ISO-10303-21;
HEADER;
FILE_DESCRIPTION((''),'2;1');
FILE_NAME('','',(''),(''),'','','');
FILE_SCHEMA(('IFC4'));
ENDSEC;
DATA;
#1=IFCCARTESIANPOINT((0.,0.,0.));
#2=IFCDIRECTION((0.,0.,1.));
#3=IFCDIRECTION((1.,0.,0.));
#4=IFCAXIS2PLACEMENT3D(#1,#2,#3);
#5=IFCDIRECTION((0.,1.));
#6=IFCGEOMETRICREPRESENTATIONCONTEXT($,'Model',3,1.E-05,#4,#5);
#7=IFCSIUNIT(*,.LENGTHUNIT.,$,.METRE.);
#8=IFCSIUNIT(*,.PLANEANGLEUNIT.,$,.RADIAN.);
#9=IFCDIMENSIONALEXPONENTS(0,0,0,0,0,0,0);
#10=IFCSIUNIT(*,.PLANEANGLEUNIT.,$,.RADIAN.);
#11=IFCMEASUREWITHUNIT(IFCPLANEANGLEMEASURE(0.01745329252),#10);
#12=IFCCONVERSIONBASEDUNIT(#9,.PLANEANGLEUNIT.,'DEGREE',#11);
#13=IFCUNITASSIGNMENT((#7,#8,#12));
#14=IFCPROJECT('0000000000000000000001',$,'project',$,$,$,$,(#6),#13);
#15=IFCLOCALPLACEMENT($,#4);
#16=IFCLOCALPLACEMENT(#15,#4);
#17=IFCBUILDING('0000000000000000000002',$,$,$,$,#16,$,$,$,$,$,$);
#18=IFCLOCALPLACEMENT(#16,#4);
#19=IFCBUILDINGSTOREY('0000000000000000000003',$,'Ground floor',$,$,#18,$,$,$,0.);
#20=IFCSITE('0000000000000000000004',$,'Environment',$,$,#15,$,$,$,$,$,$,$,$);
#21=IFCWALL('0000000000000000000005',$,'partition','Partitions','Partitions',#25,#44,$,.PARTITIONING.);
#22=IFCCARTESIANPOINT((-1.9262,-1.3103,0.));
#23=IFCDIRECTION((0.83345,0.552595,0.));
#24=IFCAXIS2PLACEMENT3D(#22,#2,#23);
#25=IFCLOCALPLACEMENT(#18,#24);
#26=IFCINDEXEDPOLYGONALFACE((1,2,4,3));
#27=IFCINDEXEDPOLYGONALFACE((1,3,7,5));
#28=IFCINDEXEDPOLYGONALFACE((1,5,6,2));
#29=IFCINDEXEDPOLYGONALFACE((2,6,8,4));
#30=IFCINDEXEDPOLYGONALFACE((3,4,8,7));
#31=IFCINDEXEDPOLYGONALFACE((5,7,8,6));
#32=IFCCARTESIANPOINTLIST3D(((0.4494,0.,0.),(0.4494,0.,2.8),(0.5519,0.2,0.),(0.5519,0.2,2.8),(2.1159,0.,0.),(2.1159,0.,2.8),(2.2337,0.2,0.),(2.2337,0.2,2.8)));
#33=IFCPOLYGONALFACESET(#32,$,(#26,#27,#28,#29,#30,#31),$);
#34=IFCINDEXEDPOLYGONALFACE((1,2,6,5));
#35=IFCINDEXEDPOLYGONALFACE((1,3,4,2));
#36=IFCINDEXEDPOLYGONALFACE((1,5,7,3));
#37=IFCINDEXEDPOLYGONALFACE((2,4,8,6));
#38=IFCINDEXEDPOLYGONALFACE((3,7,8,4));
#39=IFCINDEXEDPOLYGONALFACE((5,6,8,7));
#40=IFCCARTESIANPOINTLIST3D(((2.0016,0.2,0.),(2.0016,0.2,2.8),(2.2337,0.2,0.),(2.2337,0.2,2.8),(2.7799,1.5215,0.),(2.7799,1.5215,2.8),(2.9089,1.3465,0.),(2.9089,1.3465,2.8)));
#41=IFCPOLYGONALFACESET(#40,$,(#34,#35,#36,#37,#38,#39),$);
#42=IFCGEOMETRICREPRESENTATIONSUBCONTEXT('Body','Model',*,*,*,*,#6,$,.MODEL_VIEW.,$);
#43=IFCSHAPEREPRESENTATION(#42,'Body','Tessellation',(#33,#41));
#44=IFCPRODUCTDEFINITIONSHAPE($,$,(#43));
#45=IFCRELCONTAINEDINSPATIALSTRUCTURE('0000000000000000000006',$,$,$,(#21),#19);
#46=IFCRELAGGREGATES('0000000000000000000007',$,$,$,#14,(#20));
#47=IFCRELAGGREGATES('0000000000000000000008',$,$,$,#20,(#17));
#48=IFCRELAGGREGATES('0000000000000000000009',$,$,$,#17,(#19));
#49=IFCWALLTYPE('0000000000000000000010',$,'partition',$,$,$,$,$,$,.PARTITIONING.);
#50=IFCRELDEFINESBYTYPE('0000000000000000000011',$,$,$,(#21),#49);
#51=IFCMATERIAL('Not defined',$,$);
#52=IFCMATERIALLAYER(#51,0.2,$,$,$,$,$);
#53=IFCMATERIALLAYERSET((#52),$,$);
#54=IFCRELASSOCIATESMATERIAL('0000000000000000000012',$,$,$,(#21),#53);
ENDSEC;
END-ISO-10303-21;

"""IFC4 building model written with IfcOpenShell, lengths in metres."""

from ifc_helpers import new_model, entity, si_unit, converted_unit, direction, frame, origin_with_axes, place, context, subcontext, project, spatial, material, layer, layer_set, layer_usage, type_object, element, save


model = new_model("IFC4")

# Units and contexts
model_context = context("Model", 3, precision=1e-05, world=origin_with_axes(), true_north=direction((0.0, 1.0)))
body_context = subcontext(model_context, "Body", "Model", "MODEL_VIEW")
ifc_project = project(units=[si_unit("LENGTHUNIT", "METRE"), si_unit("PLANEANGLEUNIT", "RADIAN"), converted_unit("PLANEANGLEUNIT", "DEGREE", entity("IfcPlaneAngleMeasure", 0.01745329252), si_unit("PLANEANGLEUNIT", "RADIAN"), dimensions=[0, 0, 0, 0, 0, 0, 0])], contexts=[model_context])

# Site, building, storey
site_placement = place(None, origin_with_axes())
site = spatial("IfcSite", under=ifc_project, at=site_placement, Name="Environment")
building_placement = place(site_placement, origin_with_axes())
building = spatial("IfcBuilding", under=site, at=building_placement)
storey_placement = place(building_placement, origin_with_axes())
storey = spatial("IfcBuildingStorey", under=building, at=storey_placement, Name="Ground floor", Elevation=0.0)

# Shared definitions
ifc_material = material(Name="Not defined")

# Shared definitions
wall_type_1 = type_object("IfcWallType", Name="partition", PredefinedType="PARTITIONING")

# Wall
ifc_layer_1 = layer(ifc_material, 0.2)
ifc_layer_set_1 = layer_set([ifc_layer_1])
ifc_layer_usage_1 = layer_usage(ifc_layer_set_1, "AXIS2", "POSITIVE", 0.0)
wall_1_placement = place(storey_placement, frame((-1.9262, -1.3103, 0.0), z_axis=(0.0, 0.0, 1.0), x_axis=(0.83345, 0.552595, 0.0)))
cartesian_point_1 = entity("IfcCartesianPoint", [-0.8409, -1.4])
cartesian_point_2 = entity("IfcCartesianPoint", [-0.8332, -1.4])
cartesian_point_3 = entity("IfcCartesianPoint", [-0.7668, -1.4])
cartesian_point_4 = entity("IfcCartesianPoint", [-0.6652, -1.4])
element("IfcWall", 1, at=wall_1_placement, inside=storey, type_object=wall_type_1, material=ifc_layer_usage_1, Name="partition", Description="Partitions", ObjectType="Partitions", PredefinedType="PARTITIONING", context=body_context, shape_type="SolidModel", body=[
    entity("IfcExtrudedAreaSolidTapered", entity("IfcArbitraryClosedProfileDef", "AREA", None, entity("IfcPolyline", [cartesian_point_1, entity("IfcCartesianPoint", [0.8409, -1.4]), entity("IfcCartesianPoint", [0.8409, 1.4]), entity("IfcCartesianPoint", [-0.8409, 1.4]), cartesian_point_1])), entity("IfcAxis2Placement3D", entity("IfcCartesianPoint", [1.3928, 0.2, 1.4]), entity("IfcDirection", [0.0, -1.0, 0.0]), entity("IfcDirection", [1.0, 0.0, 0.0])), entity("IfcDirection", [-0.482345, 0.0, 0.875981]), 0.2283, entity("IfcArbitraryClosedProfileDef", "AREA", None, entity("IfcPolyline", [cartesian_point_2, entity("IfcCartesianPoint", [0.8332, -1.4]), entity("IfcCartesianPoint", [0.8332, 1.4]), entity("IfcCartesianPoint", [-0.8332, 1.4]), cartesian_point_2]))),
    entity("IfcExtrudedAreaSolidTapered", entity("IfcArbitraryClosedProfileDef", "AREA", None, entity("IfcPolyline", [cartesian_point_3, entity("IfcCartesianPoint", [0.7668, -1.4]), entity("IfcCartesianPoint", [0.7668, 1.4]), entity("IfcCartesianPoint", [-0.7668, 1.4]), cartesian_point_3])), entity("IfcAxis2Placement3D", entity("IfcCartesianPoint", [2.3907, 0.8608, 1.4]), entity("IfcDirection", [0.861676, -0.507459, 0.0]), entity("IfcDirection", [0.507459, 0.861676, 0.0])), entity("IfcDirection", [0.080771, 0.0, 0.996733]), 0.2007, entity("IfcArbitraryClosedProfileDef", "AREA", None, entity("IfcPolyline", [cartesian_point_4, entity("IfcCartesianPoint", [0.6652, -1.4]), entity("IfcCartesianPoint", [0.6652, 1.4]), entity("IfcCartesianPoint", [-0.6652, 1.4]), cartesian_point_4]))),
])

save(model, "model.ifc")
